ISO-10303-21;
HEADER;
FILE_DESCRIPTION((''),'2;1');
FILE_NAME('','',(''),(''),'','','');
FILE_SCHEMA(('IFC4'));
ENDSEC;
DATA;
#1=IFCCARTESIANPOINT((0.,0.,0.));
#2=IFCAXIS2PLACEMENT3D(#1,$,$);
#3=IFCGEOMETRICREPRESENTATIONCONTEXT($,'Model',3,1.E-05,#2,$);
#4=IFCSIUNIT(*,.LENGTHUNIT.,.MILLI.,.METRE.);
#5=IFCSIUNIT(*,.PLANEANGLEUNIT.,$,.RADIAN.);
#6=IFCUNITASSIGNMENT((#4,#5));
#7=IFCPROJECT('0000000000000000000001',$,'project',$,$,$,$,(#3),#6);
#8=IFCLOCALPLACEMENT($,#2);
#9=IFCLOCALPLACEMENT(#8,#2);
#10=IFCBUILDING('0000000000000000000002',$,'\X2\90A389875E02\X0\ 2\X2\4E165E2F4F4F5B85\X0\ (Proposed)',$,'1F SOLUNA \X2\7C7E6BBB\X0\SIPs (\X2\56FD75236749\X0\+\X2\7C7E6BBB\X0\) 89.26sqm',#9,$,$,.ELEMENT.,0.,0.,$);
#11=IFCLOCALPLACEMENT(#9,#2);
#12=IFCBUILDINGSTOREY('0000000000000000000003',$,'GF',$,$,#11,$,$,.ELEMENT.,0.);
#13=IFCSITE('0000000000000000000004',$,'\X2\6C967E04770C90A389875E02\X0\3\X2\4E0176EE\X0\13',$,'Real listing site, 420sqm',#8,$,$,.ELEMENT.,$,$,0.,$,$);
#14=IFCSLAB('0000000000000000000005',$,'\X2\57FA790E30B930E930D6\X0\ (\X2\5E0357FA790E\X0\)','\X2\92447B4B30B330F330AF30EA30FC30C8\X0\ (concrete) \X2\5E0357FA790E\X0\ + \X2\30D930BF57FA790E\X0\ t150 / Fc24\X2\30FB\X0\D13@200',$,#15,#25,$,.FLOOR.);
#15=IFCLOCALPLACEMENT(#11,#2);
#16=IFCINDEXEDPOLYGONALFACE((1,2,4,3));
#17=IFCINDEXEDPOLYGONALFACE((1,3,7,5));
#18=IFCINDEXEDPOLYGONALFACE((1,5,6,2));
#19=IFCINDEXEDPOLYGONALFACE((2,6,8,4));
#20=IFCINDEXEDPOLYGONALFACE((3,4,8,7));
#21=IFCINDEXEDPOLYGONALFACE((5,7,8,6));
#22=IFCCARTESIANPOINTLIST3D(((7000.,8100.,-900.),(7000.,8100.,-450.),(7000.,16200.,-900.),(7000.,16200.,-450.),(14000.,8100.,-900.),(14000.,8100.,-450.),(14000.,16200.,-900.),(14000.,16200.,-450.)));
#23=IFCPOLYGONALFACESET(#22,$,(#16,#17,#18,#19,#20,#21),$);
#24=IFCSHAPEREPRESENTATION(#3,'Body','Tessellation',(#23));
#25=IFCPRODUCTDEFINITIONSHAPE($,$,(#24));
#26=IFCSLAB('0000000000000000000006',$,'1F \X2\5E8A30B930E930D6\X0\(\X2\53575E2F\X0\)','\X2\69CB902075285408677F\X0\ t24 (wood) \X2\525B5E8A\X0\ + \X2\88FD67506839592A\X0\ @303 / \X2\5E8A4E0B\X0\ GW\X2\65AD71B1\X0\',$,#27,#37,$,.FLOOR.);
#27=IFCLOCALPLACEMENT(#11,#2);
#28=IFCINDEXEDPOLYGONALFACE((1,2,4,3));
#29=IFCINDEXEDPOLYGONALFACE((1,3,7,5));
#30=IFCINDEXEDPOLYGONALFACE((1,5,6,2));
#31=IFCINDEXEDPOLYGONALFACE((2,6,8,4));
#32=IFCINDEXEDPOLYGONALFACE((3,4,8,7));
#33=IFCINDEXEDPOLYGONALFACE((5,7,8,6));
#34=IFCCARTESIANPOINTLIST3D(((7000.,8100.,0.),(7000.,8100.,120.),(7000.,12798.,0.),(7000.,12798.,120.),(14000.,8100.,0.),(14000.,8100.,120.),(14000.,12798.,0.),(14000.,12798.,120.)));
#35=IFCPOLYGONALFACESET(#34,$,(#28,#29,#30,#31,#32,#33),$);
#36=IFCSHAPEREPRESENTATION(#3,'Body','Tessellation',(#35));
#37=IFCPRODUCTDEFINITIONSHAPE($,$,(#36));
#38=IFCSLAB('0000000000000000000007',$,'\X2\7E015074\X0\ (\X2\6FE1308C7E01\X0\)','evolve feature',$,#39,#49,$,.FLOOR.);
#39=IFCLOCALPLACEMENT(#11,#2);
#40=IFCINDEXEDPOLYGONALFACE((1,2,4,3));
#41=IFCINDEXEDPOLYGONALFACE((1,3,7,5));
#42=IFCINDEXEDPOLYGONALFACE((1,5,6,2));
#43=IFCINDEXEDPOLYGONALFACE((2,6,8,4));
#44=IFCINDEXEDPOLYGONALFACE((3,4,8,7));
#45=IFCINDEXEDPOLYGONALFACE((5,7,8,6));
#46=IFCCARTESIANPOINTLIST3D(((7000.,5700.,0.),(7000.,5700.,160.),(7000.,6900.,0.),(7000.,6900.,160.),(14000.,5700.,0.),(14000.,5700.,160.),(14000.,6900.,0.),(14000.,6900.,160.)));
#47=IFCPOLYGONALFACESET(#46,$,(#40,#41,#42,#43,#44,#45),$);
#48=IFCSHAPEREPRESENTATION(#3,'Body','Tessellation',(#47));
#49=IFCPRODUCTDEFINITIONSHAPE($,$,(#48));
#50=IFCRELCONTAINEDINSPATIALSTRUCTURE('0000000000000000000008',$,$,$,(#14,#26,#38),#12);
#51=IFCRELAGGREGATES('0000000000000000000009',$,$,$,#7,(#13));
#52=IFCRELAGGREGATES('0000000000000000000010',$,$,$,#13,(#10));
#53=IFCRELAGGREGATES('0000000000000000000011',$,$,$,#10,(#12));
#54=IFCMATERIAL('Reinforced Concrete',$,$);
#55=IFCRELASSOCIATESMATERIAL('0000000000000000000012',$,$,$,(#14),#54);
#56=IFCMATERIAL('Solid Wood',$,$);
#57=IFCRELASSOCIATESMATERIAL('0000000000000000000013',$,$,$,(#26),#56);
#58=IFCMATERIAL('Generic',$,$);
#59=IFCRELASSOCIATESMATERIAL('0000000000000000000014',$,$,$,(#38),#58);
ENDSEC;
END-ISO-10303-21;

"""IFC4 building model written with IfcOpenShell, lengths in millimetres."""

from ifc_helpers import new_model, si_unit, frame, frame_2d, origin, place, context, project, spatial, rectangle, extrude, material, element, save


model = new_model("IFC4")

# Units and contexts
model_context = context("Model", 3, precision=1e-05, world=origin())
ifc_project = project(units=[si_unit("LENGTHUNIT", "METRE", prefix="MILLI"), si_unit("PLANEANGLEUNIT", "RADIAN")], contexts=[model_context])

# Site, building, storey
site_placement = place(None, origin())
site = spatial("IfcSite", under=ifc_project, at=site_placement, Name="沖縄県那覇市3丁目13", ObjectType="Real listing site, 420sqm", CompositionType="ELEMENT", RefElevation=0.0)
building_placement = place(site_placement, origin())
building = spatial("IfcBuilding", under=site, at=building_placement, Name="那覇市 2世帯住宅 (Proposed)", ObjectType="1F SOLUNA 籾殻SIPs (国産杉+籾殻) 89.26sqm", CompositionType="ELEMENT", ElevationOfRefHeight=0.0, ElevationOfTerrain=0.0)
storey_placement = place(building_placement, origin())
storey = spatial("IfcBuildingStorey", under=building, at=storey_placement, Name="GF", CompositionType="ELEMENT", Elevation=0.0)

# Slabs
ifc_material_1 = material(Name="Reinforced Concrete")
slab_1_placement = place(storey_placement, frame((3500.0, 4050.0, -450.0)))
element("IfcSlab", 1, at=slab_1_placement, inside=storey, material=ifc_material_1, Name="基礎スラブ (布基礎)", Description="鉄筋コンクリート (concrete) 布基礎 + ベタ基礎 t150 / Fc24・D13@200", PredefinedType="FLOOR", context=model_context, shape_type="SweptSolid", body=[
    extrude(rectangle(XDim=7000.0, YDim=8100.0, at=frame_2d((3500.0, 4050.0))), frame((3500.0, 4050.0, -450.0)), (0.0, 0.0, 1.0), 450.0),
])
ifc_material_2 = material(Name="Solid Wood")
slab_2_placement = place(storey_placement, frame((3500.0, 4050.0, 0.0)))
element("IfcSlab", 2, at=slab_2_placement, inside=storey, material=ifc_material_2, Name="1F 床スラブ(南帯)", Description="構造用合板 t24 (wood) 剛床 + 製材根太 @303 / 床下 GW断熱", PredefinedType="FLOOR", context=model_context, shape_type="SweptSolid", body=[
    extrude(rectangle(XDim=7000.0, YDim=4698.0, at=frame_2d((3500.0, 2349.0))), frame((3500.0, 4050.0, 0.0)), (0.0, 0.0, 1.0), 120.0),
])
ifc_material_3 = material(Name="Generic")
slab_3_placement = place(storey_placement, frame((3500.0, 2850.0, 0.0)))
element("IfcSlab", 3, at=slab_3_placement, inside=storey, material=ifc_material_3, Name="縁側 (濡れ縁)", Description="evolve feature", PredefinedType="FLOOR", context=model_context, shape_type="SweptSolid", body=[
    extrude(rectangle(XDim=7000.0, YDim=1200.0, at=frame_2d((3500.0, 600.0))), frame((3500.0, 2850.0, 0.0)), (0.0, 0.0, 1.0), 160.0),
])

save(model, "model.ifc")
